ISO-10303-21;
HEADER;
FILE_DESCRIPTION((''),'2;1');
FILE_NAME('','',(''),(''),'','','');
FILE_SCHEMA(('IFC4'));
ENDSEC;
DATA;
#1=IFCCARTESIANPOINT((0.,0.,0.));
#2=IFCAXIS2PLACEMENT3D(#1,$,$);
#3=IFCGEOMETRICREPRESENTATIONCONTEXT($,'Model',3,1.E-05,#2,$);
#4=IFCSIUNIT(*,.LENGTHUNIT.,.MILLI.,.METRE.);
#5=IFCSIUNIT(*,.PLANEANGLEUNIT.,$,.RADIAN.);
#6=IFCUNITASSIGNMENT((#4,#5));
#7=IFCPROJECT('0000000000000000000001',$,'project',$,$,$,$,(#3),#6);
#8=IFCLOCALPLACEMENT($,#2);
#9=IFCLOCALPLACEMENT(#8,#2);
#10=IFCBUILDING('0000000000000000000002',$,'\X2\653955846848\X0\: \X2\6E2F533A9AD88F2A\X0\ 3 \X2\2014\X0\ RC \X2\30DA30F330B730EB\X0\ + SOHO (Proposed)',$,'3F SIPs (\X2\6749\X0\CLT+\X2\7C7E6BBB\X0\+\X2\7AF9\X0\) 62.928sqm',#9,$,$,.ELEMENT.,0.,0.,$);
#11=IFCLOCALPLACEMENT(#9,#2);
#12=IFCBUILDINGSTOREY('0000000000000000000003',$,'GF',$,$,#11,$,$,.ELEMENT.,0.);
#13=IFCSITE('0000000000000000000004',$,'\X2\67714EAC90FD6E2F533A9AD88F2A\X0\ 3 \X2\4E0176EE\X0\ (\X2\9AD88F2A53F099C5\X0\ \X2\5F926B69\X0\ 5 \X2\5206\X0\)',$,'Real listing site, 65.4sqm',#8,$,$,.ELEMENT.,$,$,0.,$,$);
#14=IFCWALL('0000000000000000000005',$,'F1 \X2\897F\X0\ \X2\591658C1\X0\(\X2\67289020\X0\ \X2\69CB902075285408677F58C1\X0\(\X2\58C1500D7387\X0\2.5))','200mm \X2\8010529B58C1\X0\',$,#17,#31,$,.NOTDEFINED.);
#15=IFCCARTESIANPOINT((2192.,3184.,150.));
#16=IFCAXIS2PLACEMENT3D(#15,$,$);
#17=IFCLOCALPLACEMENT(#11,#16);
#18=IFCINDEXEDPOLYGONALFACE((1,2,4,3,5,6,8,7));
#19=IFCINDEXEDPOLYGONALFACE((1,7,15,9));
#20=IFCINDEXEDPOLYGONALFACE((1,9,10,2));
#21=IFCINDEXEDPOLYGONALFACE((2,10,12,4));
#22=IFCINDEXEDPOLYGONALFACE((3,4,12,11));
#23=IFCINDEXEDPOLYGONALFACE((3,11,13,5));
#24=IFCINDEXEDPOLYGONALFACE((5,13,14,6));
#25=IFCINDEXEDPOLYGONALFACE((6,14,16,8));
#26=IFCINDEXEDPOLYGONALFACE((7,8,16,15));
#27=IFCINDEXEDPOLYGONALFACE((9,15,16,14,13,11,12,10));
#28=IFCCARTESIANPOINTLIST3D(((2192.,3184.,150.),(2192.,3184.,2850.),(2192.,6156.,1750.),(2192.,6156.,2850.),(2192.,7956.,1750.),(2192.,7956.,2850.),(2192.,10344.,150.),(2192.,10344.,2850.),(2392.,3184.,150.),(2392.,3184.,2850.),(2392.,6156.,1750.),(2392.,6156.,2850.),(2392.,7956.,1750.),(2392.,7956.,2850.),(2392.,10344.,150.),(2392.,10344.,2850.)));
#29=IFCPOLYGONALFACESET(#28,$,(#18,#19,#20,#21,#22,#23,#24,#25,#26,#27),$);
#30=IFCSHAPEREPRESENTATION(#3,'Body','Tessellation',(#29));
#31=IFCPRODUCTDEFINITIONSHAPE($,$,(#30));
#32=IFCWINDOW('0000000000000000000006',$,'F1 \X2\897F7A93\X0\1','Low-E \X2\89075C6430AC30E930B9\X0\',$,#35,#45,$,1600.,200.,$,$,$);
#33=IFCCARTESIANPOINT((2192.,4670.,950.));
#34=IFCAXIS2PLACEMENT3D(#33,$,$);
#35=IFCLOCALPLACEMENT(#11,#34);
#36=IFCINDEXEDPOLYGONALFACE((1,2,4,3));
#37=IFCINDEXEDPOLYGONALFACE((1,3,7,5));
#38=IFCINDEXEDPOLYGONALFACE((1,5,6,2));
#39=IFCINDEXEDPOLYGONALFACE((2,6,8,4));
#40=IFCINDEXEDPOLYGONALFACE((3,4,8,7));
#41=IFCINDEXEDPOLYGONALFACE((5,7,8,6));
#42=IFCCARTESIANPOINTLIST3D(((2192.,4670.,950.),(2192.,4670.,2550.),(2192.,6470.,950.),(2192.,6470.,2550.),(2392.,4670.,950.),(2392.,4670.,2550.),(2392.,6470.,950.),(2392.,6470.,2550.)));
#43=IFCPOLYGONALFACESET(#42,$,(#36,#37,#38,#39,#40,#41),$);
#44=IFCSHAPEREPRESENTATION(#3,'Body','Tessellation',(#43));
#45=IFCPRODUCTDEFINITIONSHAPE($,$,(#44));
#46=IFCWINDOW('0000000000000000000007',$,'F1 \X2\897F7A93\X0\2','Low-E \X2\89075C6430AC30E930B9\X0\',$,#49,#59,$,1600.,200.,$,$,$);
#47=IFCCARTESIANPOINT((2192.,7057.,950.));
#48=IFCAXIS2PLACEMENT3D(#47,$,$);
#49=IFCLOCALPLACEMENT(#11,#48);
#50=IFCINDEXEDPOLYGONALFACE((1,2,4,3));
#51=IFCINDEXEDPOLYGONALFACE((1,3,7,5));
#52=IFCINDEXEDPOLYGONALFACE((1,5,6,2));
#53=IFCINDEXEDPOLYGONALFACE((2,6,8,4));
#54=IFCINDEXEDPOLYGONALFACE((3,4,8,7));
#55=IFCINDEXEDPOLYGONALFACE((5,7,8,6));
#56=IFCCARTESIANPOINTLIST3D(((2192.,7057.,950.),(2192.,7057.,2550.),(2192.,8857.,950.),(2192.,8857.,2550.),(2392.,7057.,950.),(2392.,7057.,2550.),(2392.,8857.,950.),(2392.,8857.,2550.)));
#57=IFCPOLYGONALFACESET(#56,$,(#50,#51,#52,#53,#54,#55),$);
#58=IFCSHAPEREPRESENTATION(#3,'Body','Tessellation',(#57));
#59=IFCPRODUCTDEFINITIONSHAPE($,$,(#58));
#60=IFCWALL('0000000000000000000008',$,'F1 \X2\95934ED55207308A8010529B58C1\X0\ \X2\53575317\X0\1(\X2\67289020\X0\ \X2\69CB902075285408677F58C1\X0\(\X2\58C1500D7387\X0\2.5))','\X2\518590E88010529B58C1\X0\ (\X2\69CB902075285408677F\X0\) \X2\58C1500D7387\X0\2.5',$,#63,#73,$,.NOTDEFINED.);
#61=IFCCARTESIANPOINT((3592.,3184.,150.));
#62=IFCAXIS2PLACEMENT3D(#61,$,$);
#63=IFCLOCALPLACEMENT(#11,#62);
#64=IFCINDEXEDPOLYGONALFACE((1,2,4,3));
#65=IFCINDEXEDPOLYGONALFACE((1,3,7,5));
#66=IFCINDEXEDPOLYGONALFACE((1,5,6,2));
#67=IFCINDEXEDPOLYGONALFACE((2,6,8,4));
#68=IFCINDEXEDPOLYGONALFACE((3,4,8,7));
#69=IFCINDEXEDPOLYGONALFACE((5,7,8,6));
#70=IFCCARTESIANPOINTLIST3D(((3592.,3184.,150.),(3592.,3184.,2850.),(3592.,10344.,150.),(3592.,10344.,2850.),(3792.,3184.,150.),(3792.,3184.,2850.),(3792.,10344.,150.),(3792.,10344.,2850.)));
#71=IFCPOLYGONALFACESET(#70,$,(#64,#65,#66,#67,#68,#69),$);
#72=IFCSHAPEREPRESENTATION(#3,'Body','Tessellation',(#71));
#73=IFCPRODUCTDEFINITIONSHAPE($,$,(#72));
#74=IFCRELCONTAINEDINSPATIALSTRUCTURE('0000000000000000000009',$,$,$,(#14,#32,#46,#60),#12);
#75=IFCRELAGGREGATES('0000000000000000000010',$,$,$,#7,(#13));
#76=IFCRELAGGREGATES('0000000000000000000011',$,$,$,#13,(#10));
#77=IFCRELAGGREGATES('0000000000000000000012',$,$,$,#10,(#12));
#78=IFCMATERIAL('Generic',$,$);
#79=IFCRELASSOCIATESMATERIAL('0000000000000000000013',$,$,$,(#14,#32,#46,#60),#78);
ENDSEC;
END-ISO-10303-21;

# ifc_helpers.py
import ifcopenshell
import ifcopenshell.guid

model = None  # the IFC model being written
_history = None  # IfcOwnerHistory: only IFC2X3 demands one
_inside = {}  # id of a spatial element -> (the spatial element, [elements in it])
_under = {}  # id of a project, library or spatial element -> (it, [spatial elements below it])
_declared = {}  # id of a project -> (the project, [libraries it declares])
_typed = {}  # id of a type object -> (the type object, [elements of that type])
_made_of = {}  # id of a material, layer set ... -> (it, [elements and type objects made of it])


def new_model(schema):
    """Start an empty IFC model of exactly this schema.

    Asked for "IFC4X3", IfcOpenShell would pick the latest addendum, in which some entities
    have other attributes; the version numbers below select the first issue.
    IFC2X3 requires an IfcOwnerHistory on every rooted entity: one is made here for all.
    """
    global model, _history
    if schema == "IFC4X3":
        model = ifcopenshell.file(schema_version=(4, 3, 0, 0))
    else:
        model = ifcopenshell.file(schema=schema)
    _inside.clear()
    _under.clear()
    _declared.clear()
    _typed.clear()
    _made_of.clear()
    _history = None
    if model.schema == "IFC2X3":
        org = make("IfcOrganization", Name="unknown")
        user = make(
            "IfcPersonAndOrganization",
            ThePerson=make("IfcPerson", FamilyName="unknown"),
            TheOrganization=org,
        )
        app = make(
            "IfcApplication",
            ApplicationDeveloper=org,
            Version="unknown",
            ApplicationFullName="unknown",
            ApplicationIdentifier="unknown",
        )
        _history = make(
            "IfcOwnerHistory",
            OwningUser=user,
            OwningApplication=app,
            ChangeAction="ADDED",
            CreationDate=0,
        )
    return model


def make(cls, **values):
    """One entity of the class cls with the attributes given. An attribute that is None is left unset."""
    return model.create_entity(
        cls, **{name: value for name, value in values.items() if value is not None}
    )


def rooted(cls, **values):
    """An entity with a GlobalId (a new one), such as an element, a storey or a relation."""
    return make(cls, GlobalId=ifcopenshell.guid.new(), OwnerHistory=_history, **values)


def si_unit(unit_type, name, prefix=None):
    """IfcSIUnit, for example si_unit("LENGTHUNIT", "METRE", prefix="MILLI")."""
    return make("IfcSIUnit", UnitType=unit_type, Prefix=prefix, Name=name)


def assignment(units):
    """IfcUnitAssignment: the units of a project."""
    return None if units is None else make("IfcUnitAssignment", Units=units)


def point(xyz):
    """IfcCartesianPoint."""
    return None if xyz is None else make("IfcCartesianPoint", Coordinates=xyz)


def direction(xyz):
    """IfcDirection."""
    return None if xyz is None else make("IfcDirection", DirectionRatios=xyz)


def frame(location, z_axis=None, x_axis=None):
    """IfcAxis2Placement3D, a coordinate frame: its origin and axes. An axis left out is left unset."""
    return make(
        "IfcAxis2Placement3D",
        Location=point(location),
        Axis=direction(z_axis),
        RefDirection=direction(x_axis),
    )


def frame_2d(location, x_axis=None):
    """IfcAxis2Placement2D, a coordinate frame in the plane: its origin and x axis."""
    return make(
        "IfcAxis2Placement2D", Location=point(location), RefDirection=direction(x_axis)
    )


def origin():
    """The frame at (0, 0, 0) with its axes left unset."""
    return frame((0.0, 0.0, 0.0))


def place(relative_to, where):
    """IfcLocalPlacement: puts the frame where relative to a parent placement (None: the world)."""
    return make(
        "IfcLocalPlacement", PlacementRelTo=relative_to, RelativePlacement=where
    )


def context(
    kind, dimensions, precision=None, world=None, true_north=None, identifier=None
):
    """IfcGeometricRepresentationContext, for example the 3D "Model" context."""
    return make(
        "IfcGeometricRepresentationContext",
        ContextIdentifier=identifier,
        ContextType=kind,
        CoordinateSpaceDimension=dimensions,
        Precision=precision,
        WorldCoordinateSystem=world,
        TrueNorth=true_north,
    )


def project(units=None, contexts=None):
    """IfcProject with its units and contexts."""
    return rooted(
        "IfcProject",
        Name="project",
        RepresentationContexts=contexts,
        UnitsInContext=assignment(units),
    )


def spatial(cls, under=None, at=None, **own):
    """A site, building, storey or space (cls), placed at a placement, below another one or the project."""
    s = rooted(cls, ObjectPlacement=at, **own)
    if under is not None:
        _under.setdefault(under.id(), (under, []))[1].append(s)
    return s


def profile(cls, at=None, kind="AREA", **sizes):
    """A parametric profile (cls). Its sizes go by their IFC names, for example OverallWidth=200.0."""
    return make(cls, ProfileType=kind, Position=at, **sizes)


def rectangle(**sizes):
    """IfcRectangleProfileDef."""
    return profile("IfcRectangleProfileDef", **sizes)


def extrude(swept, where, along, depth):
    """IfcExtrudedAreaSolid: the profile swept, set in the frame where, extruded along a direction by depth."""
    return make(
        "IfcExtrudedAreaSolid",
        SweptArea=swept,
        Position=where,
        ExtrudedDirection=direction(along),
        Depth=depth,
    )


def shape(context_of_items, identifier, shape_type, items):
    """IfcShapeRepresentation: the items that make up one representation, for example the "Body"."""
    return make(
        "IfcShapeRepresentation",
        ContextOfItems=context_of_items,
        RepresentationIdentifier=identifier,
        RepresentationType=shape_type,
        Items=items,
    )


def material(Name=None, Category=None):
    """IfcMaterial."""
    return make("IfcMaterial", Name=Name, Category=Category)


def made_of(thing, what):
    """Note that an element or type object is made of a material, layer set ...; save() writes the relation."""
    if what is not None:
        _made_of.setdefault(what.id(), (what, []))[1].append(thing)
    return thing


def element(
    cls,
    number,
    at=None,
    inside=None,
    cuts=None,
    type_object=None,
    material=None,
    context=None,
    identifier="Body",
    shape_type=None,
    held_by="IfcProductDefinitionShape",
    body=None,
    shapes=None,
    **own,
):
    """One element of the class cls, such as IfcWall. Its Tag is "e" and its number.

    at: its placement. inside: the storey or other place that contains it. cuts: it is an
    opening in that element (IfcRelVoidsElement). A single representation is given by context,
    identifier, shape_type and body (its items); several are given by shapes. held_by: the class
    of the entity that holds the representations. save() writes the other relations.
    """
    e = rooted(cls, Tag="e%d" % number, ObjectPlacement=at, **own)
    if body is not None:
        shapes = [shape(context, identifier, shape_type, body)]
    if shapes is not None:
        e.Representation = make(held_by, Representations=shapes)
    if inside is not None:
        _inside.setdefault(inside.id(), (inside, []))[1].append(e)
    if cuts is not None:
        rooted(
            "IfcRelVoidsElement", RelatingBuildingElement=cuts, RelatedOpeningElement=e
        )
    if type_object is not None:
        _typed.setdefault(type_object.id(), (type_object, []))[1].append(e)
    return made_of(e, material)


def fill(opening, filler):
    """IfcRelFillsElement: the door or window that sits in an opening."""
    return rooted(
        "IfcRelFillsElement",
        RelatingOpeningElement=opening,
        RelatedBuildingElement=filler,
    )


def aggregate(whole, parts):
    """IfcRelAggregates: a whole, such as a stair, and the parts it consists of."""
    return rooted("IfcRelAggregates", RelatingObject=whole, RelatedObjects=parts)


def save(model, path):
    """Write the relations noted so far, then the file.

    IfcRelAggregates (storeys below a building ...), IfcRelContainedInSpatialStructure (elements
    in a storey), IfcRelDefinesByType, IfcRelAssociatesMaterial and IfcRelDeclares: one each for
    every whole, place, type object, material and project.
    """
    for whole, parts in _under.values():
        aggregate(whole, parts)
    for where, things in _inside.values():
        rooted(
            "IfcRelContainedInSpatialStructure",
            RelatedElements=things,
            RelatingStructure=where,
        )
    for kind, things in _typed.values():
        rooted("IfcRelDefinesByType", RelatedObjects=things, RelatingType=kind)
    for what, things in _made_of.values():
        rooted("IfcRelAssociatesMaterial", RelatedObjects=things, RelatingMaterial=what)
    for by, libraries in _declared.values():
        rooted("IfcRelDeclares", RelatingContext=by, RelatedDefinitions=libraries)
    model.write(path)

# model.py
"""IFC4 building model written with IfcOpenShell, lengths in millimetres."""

from ifc_helpers import new_model, si_unit, frame, frame_2d, origin, place, context, project, spatial, rectangle, extrude, material, element, fill, save


model = new_model("IFC4")

# Units and contexts
model_context = context("Model", 3, precision=1e-05, world=origin())
ifc_project = project(units=[si_unit("LENGTHUNIT", "METRE", prefix="MILLI"), si_unit("PLANEANGLEUNIT", "RADIAN")], contexts=[model_context])

# Site, building, storey
site_placement = place(None, origin())
site = spatial("IfcSite", under=ifc_project, at=site_placement, Name="東京都港区高輪 3 丁目 (高輪台駅 徒歩 5 分)", ObjectType="Real listing site, 65.4sqm", CompositionType="ELEMENT", RefElevation=0.0)
building_placement = place(site_placement, origin())
building = spatial("IfcBuilding", under=site, at=building_placement, Name="改善案: 港区高輪 3 — RC ペンシル + SOHO (Proposed)", ObjectType="3F SIPs (杉CLT+籾殻+竹) 62.928sqm", CompositionType="ELEMENT", ElevationOfRefHeight=0.0, ElevationOfTerrain=0.0)
storey_placement = place(building_placement, origin())
storey = spatial("IfcBuildingStorey", under=building, at=storey_placement, Name="GF", CompositionType="ELEMENT", Elevation=0.0)

# Shared definitions
ifc_material_1 = material(Name="Generic")

# Wall, openings, windows
wall_1_placement = place(storey_placement, frame((2192.0, 3184.0, 150.0)))
wall_1 = element("IfcWall", 1, at=wall_1_placement, inside=storey, material=ifc_material_1, Name="F1 西 外壁(木造 構造用合板壁(壁倍率2.5))", Description="200mm 耐力壁", PredefinedType="NOTDEFINED", context=model_context, shape_type="SweptSolid", body=[
    extrude(rectangle(XDim=200.0, YDim=7160.0, at=frame_2d((100.0, 3580.0))), frame((2192.0, 3184.0, 150.0)), (0.0, 0.0, 1.0), 2700.0),
])
opening_1_placement = place(storey_placement, frame((2192.0, 4670.0, 950.0)))
opening_1 = element("IfcOpeningElement", 2, at=opening_1_placement, cuts=wall_1, PredefinedType="NOTDEFINED", context=model_context, shape_type="SweptSolid", body=[
    extrude(rectangle(XDim=200.0, YDim=1800.0, at=frame_2d((100.0, 900.0))), frame((2192.0, 4670.0, 950.0)), (0.0, 0.0, 1.0), 1600.0),
])
opening_2_placement = place(storey_placement, frame((2192.0, 7057.0, 950.0)))
opening_2 = element("IfcOpeningElement", 3, at=opening_2_placement, cuts=wall_1, PredefinedType="NOTDEFINED", context=model_context, shape_type="SweptSolid", body=[
    extrude(rectangle(XDim=200.0, YDim=1800.0, at=frame_2d((100.0, 900.0))), frame((2192.0, 7057.0, 950.0)), (0.0, 0.0, 1.0), 1600.0),
])
window_1_placement = place(storey_placement, frame((2192.0, 4670.0, 950.0)))
window_1 = element("IfcWindow", 4, at=window_1_placement, inside=storey, material=ifc_material_1, Name="F1 西窓1", Description="Low-E 複層ガラス", OverallHeight=1600.0, OverallWidth=200.0, context=model_context, shape_type="SweptSolid", body=[
    extrude(rectangle(XDim=200.0, YDim=1800.0, at=frame_2d((100.0, 900.0))), frame((2192.0, 4670.0, 950.0)), (0.0, 0.0, 1.0), 1600.0),
])
fill(opening_1, window_1)
window_2_placement = place(storey_placement, frame((2192.0, 7057.0, 950.0)))
window_2 = element("IfcWindow", 5, at=window_2_placement, inside=storey, material=ifc_material_1, Name="F1 西窓2", Description="Low-E 複層ガラス", OverallHeight=1600.0, OverallWidth=200.0, context=model_context, shape_type="SweptSolid", body=[
    extrude(rectangle(XDim=200.0, YDim=1800.0, at=frame_2d((100.0, 900.0))), frame((2192.0, 7057.0, 950.0)), (0.0, 0.0, 1.0), 1600.0),
])
fill(opening_2, window_2)

# Wall
wall_2_placement = place(storey_placement, frame((3592.0, 3184.0, 150.0)))
element("IfcWall", 6, at=wall_2_placement, inside=storey, material=ifc_material_1, Name="F1 間仕切り耐力壁 南北1(木造 構造用合板壁(壁倍率2.5))", Description="内部耐力壁 (構造用合板) 壁倍率2.5", PredefinedType="NOTDEFINED", context=model_context, shape_type="SweptSolid", body=[
    extrude(rectangle(XDim=200.0, YDim=7160.0, at=frame_2d((100.0, 3580.0))), frame((3592.0, 3184.0, 150.0)), (0.0, 0.0, 1.0), 2700.0),
])

save(model, "model.ifc")
